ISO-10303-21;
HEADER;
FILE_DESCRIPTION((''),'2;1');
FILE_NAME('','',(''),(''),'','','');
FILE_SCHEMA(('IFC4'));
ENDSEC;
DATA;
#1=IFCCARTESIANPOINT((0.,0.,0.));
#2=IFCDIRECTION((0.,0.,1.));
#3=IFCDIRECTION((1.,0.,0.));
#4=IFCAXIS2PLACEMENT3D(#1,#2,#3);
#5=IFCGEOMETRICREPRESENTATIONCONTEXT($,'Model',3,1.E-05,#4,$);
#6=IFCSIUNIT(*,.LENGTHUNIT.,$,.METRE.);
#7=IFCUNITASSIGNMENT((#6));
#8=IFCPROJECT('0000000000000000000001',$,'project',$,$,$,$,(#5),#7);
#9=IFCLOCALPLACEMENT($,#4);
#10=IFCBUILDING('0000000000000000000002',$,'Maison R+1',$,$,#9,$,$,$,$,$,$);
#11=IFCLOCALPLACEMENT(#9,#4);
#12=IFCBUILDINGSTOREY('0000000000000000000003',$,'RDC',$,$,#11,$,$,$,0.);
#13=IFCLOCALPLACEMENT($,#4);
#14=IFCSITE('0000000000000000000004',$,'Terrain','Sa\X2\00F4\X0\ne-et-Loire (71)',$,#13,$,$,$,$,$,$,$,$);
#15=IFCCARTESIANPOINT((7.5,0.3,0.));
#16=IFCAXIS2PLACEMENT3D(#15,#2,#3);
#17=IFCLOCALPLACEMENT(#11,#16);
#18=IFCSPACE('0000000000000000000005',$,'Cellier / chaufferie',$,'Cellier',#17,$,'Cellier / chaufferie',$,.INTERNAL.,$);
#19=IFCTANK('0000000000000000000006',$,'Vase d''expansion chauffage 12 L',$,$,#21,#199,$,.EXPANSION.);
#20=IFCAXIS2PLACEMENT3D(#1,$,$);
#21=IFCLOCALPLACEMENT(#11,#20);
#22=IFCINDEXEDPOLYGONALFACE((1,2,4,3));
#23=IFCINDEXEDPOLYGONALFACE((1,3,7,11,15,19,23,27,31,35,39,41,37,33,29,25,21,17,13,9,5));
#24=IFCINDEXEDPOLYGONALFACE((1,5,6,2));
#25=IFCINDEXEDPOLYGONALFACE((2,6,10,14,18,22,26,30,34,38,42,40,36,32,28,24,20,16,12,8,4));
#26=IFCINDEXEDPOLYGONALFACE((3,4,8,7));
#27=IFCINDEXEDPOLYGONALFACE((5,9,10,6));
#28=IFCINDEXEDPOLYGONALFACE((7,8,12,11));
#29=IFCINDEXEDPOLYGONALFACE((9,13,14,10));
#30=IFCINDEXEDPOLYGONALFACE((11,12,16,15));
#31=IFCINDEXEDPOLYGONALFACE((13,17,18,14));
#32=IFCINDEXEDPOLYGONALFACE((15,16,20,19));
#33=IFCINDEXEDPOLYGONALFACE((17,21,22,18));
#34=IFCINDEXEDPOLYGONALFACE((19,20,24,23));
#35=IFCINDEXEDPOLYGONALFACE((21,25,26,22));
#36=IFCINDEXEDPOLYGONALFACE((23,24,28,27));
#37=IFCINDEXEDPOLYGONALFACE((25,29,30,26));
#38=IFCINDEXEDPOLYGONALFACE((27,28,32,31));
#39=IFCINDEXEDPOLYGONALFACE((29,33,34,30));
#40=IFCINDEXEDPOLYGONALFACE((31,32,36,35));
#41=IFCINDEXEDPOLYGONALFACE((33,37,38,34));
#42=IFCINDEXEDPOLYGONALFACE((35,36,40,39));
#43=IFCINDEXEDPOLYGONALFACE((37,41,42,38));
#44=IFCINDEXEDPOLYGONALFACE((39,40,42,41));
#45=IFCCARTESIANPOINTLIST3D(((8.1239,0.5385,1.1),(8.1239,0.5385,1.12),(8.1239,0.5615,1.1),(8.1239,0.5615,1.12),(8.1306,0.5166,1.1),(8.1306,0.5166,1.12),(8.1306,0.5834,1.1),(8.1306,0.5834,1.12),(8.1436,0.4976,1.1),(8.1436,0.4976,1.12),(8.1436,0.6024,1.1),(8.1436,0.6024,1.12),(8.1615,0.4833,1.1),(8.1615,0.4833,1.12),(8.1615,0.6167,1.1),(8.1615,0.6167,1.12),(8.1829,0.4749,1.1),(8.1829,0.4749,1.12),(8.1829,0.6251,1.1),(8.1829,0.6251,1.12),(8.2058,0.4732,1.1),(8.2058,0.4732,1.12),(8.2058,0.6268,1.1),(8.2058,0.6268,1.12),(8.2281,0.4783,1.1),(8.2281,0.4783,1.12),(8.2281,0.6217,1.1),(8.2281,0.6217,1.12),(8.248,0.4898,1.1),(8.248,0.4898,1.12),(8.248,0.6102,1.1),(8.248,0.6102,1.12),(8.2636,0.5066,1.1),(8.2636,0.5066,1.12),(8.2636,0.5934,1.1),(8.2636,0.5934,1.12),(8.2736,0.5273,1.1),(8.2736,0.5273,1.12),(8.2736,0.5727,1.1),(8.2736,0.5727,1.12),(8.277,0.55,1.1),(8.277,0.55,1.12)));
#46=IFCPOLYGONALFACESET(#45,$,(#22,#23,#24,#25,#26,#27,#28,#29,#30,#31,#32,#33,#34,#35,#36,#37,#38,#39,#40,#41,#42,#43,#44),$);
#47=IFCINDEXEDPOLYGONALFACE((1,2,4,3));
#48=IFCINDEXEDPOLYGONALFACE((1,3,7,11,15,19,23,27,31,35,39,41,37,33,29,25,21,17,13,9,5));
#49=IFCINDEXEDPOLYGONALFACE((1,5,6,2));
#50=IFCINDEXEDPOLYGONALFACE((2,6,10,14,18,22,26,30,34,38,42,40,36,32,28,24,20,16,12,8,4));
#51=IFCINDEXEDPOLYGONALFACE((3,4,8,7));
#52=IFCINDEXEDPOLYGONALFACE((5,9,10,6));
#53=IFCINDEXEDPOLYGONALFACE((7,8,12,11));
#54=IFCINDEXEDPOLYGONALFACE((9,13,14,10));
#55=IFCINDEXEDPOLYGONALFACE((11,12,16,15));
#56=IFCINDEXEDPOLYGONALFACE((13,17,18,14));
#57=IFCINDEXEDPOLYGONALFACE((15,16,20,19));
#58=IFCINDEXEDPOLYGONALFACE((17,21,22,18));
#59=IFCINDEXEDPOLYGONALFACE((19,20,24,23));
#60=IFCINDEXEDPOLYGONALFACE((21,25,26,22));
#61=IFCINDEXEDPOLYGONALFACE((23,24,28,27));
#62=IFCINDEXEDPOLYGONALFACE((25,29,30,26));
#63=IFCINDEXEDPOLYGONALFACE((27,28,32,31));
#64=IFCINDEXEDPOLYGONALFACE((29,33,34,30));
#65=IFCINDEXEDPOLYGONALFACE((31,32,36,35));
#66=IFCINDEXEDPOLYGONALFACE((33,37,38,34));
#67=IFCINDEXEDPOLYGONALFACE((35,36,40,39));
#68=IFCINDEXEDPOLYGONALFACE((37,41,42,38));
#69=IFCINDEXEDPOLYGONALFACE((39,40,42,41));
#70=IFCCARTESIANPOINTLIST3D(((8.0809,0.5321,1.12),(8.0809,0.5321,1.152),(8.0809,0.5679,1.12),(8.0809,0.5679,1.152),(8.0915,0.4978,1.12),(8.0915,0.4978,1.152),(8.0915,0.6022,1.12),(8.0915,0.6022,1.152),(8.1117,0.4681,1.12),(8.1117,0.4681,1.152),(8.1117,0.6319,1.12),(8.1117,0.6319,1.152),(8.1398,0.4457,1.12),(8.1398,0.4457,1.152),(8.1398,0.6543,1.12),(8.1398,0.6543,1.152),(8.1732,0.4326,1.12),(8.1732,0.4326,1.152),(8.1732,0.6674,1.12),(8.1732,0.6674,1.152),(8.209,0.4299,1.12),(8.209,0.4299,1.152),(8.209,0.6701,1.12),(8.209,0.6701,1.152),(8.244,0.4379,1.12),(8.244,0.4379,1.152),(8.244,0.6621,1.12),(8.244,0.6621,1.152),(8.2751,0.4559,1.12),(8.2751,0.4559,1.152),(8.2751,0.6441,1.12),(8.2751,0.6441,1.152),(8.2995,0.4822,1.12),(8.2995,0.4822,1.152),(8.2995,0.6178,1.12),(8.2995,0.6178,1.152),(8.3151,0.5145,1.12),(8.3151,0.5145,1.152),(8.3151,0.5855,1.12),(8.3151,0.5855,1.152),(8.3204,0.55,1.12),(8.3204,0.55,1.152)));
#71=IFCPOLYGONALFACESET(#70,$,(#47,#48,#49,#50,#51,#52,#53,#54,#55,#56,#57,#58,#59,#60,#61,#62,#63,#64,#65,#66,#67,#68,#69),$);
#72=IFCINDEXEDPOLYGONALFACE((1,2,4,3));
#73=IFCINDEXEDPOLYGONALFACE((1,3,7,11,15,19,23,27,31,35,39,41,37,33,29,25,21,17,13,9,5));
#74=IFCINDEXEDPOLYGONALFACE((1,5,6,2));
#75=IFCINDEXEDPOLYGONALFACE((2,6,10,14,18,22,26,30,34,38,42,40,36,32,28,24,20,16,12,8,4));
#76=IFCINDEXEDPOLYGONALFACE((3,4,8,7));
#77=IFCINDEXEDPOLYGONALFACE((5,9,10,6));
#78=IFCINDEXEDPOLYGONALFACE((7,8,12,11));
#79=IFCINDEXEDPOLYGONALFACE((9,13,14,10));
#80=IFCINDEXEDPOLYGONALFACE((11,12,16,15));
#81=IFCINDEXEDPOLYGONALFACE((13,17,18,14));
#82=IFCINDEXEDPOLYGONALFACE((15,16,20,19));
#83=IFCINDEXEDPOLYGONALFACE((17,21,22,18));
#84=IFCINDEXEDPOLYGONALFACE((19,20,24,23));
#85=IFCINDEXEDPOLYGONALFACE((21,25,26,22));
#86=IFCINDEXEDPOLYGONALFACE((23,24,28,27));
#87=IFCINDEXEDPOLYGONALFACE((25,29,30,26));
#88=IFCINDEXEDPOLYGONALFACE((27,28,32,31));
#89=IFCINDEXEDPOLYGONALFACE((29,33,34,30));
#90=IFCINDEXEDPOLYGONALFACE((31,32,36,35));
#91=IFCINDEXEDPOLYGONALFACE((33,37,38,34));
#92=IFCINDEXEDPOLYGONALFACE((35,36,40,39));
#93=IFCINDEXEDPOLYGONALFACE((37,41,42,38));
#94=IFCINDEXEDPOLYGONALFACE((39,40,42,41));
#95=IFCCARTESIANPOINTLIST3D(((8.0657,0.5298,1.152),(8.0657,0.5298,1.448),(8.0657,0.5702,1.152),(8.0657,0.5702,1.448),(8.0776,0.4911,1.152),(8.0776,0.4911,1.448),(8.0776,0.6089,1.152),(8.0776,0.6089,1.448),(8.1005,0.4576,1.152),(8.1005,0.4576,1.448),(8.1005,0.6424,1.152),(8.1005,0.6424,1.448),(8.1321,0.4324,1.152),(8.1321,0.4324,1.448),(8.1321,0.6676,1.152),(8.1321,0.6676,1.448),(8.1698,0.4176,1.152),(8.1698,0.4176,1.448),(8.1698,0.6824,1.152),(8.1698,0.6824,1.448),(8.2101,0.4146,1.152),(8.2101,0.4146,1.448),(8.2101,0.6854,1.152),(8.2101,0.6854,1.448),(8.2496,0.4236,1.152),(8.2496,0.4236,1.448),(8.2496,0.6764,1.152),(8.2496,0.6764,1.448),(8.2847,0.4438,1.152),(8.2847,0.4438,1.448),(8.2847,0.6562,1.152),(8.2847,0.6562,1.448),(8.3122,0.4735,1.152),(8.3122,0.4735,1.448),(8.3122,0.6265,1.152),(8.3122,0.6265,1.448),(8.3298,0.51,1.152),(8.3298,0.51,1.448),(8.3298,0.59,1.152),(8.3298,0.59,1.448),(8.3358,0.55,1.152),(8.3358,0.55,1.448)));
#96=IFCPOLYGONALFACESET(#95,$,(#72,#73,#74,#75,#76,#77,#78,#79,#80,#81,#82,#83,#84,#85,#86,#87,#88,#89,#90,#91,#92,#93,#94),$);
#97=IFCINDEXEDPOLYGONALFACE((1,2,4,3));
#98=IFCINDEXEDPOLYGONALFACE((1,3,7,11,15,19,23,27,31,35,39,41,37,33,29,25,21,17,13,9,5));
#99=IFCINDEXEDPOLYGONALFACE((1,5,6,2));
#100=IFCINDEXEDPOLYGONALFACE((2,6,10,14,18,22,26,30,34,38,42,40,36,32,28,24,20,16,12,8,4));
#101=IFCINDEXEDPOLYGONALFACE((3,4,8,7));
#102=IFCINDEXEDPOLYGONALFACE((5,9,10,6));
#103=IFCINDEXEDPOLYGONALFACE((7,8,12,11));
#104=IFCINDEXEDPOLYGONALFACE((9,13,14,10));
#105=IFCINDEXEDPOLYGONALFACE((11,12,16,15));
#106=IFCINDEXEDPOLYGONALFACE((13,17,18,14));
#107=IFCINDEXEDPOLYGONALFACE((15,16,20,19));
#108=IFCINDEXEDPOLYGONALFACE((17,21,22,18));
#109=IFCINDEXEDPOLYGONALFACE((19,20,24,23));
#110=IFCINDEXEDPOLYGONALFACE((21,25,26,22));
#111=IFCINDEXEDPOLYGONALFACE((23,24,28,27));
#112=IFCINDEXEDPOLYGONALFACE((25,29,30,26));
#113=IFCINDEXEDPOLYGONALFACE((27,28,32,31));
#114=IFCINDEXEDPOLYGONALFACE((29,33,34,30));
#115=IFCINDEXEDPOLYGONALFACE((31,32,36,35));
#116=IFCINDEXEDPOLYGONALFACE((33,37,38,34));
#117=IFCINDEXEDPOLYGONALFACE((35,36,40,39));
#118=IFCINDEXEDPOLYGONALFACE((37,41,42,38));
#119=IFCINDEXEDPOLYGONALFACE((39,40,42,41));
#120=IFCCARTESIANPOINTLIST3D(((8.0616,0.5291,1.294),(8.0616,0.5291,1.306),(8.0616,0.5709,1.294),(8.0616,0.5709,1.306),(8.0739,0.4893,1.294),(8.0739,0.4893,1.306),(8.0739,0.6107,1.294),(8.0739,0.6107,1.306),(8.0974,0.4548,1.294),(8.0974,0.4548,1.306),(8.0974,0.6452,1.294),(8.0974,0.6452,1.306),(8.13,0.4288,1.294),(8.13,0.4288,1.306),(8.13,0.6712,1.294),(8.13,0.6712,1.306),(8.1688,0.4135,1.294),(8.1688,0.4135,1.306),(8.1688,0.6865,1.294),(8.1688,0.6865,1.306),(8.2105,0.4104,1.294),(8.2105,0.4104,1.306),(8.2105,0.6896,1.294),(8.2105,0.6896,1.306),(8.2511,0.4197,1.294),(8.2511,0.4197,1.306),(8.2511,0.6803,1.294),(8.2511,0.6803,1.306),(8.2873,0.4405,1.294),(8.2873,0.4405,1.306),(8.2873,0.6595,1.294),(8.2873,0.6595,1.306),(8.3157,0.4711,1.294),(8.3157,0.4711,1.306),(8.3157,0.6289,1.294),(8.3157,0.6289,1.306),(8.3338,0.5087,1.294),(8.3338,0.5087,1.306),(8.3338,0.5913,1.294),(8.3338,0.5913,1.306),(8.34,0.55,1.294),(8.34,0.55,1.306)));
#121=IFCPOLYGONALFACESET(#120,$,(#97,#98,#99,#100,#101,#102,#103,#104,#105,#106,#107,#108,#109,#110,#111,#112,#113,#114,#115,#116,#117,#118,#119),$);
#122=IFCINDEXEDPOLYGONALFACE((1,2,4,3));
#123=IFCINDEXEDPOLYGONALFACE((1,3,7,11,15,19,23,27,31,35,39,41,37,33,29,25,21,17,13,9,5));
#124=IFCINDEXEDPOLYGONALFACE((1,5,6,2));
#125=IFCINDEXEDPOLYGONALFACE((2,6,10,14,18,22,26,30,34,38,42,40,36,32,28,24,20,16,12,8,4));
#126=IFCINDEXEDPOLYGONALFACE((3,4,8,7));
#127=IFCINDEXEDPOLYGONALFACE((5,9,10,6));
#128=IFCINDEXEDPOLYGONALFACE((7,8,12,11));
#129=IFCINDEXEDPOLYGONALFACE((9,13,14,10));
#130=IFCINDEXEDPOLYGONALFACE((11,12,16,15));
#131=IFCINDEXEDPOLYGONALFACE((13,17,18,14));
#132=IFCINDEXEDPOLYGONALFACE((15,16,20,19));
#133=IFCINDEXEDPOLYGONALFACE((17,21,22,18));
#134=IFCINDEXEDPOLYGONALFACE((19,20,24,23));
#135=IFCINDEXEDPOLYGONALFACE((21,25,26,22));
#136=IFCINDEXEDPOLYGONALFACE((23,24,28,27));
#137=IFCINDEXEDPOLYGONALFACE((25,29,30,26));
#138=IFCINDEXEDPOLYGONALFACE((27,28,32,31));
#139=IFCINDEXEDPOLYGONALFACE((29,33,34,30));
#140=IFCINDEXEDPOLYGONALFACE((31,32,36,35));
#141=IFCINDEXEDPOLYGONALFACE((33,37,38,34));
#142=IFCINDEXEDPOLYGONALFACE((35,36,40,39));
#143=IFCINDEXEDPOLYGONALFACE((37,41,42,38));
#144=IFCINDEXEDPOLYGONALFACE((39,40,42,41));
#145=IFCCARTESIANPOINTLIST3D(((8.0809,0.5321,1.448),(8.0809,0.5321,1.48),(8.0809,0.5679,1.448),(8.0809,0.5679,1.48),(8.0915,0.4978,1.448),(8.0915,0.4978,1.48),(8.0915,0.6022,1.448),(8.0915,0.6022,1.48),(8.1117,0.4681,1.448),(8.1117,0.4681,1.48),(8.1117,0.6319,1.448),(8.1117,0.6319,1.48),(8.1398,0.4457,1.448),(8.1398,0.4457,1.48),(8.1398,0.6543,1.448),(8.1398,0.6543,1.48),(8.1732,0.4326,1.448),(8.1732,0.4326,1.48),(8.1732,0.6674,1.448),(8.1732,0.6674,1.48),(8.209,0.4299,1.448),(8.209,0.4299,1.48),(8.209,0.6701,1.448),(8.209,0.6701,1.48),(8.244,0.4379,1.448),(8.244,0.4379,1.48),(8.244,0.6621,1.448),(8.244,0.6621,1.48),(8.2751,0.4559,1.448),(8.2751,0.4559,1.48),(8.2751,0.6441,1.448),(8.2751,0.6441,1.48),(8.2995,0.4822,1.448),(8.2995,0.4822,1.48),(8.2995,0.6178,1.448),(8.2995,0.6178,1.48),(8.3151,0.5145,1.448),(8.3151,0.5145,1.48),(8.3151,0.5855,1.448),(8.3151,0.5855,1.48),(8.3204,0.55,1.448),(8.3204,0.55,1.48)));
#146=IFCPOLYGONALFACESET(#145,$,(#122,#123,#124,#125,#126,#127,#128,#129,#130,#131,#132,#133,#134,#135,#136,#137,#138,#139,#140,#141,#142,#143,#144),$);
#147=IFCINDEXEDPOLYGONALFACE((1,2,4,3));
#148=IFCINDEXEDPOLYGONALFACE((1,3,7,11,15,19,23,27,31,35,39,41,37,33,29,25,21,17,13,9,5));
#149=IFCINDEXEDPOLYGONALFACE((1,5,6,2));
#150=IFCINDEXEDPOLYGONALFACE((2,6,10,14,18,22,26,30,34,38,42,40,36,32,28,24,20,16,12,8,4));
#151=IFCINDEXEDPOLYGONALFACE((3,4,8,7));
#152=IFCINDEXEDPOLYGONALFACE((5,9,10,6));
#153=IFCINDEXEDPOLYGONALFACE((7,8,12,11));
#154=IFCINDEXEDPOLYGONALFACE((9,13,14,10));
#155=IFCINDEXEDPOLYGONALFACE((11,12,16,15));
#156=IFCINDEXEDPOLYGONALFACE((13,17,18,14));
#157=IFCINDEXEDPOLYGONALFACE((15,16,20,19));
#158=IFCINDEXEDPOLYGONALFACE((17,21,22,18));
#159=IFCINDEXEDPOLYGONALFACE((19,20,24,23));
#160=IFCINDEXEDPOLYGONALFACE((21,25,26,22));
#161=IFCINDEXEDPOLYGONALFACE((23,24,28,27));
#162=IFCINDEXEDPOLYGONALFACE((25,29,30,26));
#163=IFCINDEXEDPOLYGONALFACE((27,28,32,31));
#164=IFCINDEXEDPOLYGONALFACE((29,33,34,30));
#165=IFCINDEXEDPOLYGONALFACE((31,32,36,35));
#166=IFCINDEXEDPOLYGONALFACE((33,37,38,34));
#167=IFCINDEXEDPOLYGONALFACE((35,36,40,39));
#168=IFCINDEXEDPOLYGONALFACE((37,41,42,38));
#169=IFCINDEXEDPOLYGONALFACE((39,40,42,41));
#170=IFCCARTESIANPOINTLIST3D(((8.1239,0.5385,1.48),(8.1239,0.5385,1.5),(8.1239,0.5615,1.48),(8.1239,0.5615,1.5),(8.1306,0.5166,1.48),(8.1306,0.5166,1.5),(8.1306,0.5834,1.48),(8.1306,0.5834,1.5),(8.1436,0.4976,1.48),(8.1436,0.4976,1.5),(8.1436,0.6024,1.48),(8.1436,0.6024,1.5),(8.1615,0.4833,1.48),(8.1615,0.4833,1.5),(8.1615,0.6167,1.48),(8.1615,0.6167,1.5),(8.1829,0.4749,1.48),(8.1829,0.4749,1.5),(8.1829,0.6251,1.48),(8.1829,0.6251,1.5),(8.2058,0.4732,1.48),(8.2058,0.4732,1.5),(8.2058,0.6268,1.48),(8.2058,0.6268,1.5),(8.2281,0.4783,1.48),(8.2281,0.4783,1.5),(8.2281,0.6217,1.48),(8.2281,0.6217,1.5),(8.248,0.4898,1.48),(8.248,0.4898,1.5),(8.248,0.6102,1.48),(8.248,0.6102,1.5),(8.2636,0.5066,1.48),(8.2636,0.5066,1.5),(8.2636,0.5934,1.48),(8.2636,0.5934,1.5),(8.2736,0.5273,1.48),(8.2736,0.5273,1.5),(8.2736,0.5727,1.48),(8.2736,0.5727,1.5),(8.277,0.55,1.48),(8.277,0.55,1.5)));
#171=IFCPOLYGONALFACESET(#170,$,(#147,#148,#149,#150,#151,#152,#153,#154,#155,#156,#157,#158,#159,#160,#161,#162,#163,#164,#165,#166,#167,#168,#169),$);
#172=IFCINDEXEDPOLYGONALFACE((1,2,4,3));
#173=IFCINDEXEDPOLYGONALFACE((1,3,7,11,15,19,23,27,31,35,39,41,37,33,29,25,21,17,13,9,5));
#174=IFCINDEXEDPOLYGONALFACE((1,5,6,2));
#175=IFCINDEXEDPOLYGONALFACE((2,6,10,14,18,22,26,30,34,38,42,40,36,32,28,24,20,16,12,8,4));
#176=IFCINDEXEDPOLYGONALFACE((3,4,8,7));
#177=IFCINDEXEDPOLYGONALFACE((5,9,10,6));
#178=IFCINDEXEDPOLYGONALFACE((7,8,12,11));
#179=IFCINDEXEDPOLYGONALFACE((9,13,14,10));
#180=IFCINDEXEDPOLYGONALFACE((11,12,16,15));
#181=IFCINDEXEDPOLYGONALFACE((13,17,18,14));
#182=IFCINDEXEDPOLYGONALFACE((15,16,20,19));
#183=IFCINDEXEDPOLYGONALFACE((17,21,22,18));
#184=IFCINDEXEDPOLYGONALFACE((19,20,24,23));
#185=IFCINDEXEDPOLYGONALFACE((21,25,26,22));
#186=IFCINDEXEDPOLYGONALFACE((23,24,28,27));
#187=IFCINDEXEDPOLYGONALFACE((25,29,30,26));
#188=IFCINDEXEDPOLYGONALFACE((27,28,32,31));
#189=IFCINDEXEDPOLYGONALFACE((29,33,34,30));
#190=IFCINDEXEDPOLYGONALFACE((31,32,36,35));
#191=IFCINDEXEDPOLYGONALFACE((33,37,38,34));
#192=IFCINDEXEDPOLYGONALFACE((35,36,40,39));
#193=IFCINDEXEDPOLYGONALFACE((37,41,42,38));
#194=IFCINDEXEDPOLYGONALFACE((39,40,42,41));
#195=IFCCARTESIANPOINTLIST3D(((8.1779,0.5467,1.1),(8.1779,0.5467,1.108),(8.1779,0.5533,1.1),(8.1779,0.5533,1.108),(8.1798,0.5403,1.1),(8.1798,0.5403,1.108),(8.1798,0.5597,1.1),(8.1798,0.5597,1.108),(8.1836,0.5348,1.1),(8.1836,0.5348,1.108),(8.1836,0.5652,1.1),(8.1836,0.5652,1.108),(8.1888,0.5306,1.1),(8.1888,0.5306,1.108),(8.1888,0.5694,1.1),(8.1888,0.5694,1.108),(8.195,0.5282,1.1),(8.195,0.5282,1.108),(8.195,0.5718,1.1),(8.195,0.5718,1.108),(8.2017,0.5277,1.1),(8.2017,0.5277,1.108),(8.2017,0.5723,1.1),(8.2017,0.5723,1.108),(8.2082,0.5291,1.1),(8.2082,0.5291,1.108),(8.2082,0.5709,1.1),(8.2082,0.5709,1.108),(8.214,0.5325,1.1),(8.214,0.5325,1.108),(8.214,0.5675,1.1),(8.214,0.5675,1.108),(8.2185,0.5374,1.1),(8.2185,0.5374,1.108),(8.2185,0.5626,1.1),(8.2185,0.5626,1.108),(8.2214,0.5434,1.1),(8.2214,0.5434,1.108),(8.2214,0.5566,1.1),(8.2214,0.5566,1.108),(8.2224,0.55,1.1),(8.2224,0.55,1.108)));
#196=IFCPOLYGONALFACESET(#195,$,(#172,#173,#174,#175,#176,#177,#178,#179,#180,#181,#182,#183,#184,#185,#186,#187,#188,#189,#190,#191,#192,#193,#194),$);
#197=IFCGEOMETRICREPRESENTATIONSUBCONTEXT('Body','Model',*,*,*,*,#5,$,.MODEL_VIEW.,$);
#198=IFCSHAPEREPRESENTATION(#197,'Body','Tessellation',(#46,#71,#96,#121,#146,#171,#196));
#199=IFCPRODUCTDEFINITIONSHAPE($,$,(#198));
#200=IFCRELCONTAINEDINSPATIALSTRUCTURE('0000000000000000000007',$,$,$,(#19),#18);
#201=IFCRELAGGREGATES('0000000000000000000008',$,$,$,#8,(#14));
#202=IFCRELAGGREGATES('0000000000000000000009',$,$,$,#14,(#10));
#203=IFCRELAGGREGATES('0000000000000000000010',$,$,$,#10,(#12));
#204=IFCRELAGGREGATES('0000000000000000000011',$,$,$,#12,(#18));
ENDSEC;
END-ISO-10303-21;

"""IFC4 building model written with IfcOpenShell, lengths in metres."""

from ifc_helpers import new_model, si_unit, frame, origin_with_axes, place, context, subcontext, project, spatial, circle, extrude, element, save


model = new_model("IFC4")

# Units and contexts
model_context = context("Model", 3, precision=1e-05, world=origin_with_axes())
body_context = subcontext(model_context, "Body", "Model", "MODEL_VIEW")
ifc_project = project(units=[si_unit("LENGTHUNIT", "METRE")], contexts=[model_context])

# Site, building, storey
site_placement = place(None, origin_with_axes())
site = spatial("IfcSite", under=ifc_project, at=site_placement, Name="Terrain", Description="Saône-et-Loire (71)")
building_placement = place(None, origin_with_axes())
building = spatial("IfcBuilding", under=site, at=building_placement, Name="Maison R+1")
storey_placement = place(building_placement, origin_with_axes())
storey = spatial("IfcBuildingStorey", under=building, at=storey_placement, Name="RDC", Elevation=0.0)

# Shared definitions
space_placement = place(storey_placement, frame((7.5, 0.3, 0.0), z_axis=(0.0, 0.0, 1.0), x_axis=(1.0, 0.0, 0.0)))
space = spatial("IfcSpace", under=storey, at=space_placement, Name="Cellier / chaufferie", ObjectType="Cellier", LongName="Cellier / chaufferie", PredefinedType="INTERNAL")

# Tank
tank_placement = place(space_placement, frame((0.7, 0.25, 1.1), z_axis=(0.0, 0.0, 1.0), x_axis=(1.0, 0.0, 0.0)))
element("IfcTank", 1, at=tank_placement, inside=space, Name="Vase d'expansion chauffage 12 L", PredefinedType="EXPANSION", context=body_context, shape_type="SweptSolid", body=[
    extrude(circle(Radius=0.077), origin_with_axes(), (0.0, 0.0, 1.0), 0.02),
    extrude(circle(Radius=0.1204), frame((0.0, 0.0, 0.02), z_axis=(0.0, 0.0, 1.0), x_axis=(1.0, 0.0, 0.0)), (0.0, 0.0, 1.0), 0.032),
    extrude(circle(Radius=0.1358), frame((0.0, 0.0, 0.052), z_axis=(0.0, 0.0, 1.0), x_axis=(1.0, 0.0, 0.0)), (0.0, 0.0, 1.0), 0.296),
    extrude(circle(Radius=0.14), frame((0.0, 0.0, 0.194), z_axis=(0.0, 0.0, 1.0), x_axis=(1.0, 0.0, 0.0)), (0.0, 0.0, 1.0), 0.012),
    extrude(circle(Radius=0.1204), frame((0.0, 0.0, 0.348), z_axis=(0.0, 0.0, 1.0), x_axis=(1.0, 0.0, 0.0)), (0.0, 0.0, 1.0), 0.032),
    extrude(circle(Radius=0.077), frame((0.0, 0.0, 0.38), z_axis=(0.0, 0.0, 1.0), x_axis=(1.0, 0.0, 0.0)), (0.0, 0.0, 1.0), 0.02),
    extrude(circle(Radius=0.0224), origin_with_axes(), (0.0, 0.0, 1.0), 0.008),
])

save(model, "model.ifc")
